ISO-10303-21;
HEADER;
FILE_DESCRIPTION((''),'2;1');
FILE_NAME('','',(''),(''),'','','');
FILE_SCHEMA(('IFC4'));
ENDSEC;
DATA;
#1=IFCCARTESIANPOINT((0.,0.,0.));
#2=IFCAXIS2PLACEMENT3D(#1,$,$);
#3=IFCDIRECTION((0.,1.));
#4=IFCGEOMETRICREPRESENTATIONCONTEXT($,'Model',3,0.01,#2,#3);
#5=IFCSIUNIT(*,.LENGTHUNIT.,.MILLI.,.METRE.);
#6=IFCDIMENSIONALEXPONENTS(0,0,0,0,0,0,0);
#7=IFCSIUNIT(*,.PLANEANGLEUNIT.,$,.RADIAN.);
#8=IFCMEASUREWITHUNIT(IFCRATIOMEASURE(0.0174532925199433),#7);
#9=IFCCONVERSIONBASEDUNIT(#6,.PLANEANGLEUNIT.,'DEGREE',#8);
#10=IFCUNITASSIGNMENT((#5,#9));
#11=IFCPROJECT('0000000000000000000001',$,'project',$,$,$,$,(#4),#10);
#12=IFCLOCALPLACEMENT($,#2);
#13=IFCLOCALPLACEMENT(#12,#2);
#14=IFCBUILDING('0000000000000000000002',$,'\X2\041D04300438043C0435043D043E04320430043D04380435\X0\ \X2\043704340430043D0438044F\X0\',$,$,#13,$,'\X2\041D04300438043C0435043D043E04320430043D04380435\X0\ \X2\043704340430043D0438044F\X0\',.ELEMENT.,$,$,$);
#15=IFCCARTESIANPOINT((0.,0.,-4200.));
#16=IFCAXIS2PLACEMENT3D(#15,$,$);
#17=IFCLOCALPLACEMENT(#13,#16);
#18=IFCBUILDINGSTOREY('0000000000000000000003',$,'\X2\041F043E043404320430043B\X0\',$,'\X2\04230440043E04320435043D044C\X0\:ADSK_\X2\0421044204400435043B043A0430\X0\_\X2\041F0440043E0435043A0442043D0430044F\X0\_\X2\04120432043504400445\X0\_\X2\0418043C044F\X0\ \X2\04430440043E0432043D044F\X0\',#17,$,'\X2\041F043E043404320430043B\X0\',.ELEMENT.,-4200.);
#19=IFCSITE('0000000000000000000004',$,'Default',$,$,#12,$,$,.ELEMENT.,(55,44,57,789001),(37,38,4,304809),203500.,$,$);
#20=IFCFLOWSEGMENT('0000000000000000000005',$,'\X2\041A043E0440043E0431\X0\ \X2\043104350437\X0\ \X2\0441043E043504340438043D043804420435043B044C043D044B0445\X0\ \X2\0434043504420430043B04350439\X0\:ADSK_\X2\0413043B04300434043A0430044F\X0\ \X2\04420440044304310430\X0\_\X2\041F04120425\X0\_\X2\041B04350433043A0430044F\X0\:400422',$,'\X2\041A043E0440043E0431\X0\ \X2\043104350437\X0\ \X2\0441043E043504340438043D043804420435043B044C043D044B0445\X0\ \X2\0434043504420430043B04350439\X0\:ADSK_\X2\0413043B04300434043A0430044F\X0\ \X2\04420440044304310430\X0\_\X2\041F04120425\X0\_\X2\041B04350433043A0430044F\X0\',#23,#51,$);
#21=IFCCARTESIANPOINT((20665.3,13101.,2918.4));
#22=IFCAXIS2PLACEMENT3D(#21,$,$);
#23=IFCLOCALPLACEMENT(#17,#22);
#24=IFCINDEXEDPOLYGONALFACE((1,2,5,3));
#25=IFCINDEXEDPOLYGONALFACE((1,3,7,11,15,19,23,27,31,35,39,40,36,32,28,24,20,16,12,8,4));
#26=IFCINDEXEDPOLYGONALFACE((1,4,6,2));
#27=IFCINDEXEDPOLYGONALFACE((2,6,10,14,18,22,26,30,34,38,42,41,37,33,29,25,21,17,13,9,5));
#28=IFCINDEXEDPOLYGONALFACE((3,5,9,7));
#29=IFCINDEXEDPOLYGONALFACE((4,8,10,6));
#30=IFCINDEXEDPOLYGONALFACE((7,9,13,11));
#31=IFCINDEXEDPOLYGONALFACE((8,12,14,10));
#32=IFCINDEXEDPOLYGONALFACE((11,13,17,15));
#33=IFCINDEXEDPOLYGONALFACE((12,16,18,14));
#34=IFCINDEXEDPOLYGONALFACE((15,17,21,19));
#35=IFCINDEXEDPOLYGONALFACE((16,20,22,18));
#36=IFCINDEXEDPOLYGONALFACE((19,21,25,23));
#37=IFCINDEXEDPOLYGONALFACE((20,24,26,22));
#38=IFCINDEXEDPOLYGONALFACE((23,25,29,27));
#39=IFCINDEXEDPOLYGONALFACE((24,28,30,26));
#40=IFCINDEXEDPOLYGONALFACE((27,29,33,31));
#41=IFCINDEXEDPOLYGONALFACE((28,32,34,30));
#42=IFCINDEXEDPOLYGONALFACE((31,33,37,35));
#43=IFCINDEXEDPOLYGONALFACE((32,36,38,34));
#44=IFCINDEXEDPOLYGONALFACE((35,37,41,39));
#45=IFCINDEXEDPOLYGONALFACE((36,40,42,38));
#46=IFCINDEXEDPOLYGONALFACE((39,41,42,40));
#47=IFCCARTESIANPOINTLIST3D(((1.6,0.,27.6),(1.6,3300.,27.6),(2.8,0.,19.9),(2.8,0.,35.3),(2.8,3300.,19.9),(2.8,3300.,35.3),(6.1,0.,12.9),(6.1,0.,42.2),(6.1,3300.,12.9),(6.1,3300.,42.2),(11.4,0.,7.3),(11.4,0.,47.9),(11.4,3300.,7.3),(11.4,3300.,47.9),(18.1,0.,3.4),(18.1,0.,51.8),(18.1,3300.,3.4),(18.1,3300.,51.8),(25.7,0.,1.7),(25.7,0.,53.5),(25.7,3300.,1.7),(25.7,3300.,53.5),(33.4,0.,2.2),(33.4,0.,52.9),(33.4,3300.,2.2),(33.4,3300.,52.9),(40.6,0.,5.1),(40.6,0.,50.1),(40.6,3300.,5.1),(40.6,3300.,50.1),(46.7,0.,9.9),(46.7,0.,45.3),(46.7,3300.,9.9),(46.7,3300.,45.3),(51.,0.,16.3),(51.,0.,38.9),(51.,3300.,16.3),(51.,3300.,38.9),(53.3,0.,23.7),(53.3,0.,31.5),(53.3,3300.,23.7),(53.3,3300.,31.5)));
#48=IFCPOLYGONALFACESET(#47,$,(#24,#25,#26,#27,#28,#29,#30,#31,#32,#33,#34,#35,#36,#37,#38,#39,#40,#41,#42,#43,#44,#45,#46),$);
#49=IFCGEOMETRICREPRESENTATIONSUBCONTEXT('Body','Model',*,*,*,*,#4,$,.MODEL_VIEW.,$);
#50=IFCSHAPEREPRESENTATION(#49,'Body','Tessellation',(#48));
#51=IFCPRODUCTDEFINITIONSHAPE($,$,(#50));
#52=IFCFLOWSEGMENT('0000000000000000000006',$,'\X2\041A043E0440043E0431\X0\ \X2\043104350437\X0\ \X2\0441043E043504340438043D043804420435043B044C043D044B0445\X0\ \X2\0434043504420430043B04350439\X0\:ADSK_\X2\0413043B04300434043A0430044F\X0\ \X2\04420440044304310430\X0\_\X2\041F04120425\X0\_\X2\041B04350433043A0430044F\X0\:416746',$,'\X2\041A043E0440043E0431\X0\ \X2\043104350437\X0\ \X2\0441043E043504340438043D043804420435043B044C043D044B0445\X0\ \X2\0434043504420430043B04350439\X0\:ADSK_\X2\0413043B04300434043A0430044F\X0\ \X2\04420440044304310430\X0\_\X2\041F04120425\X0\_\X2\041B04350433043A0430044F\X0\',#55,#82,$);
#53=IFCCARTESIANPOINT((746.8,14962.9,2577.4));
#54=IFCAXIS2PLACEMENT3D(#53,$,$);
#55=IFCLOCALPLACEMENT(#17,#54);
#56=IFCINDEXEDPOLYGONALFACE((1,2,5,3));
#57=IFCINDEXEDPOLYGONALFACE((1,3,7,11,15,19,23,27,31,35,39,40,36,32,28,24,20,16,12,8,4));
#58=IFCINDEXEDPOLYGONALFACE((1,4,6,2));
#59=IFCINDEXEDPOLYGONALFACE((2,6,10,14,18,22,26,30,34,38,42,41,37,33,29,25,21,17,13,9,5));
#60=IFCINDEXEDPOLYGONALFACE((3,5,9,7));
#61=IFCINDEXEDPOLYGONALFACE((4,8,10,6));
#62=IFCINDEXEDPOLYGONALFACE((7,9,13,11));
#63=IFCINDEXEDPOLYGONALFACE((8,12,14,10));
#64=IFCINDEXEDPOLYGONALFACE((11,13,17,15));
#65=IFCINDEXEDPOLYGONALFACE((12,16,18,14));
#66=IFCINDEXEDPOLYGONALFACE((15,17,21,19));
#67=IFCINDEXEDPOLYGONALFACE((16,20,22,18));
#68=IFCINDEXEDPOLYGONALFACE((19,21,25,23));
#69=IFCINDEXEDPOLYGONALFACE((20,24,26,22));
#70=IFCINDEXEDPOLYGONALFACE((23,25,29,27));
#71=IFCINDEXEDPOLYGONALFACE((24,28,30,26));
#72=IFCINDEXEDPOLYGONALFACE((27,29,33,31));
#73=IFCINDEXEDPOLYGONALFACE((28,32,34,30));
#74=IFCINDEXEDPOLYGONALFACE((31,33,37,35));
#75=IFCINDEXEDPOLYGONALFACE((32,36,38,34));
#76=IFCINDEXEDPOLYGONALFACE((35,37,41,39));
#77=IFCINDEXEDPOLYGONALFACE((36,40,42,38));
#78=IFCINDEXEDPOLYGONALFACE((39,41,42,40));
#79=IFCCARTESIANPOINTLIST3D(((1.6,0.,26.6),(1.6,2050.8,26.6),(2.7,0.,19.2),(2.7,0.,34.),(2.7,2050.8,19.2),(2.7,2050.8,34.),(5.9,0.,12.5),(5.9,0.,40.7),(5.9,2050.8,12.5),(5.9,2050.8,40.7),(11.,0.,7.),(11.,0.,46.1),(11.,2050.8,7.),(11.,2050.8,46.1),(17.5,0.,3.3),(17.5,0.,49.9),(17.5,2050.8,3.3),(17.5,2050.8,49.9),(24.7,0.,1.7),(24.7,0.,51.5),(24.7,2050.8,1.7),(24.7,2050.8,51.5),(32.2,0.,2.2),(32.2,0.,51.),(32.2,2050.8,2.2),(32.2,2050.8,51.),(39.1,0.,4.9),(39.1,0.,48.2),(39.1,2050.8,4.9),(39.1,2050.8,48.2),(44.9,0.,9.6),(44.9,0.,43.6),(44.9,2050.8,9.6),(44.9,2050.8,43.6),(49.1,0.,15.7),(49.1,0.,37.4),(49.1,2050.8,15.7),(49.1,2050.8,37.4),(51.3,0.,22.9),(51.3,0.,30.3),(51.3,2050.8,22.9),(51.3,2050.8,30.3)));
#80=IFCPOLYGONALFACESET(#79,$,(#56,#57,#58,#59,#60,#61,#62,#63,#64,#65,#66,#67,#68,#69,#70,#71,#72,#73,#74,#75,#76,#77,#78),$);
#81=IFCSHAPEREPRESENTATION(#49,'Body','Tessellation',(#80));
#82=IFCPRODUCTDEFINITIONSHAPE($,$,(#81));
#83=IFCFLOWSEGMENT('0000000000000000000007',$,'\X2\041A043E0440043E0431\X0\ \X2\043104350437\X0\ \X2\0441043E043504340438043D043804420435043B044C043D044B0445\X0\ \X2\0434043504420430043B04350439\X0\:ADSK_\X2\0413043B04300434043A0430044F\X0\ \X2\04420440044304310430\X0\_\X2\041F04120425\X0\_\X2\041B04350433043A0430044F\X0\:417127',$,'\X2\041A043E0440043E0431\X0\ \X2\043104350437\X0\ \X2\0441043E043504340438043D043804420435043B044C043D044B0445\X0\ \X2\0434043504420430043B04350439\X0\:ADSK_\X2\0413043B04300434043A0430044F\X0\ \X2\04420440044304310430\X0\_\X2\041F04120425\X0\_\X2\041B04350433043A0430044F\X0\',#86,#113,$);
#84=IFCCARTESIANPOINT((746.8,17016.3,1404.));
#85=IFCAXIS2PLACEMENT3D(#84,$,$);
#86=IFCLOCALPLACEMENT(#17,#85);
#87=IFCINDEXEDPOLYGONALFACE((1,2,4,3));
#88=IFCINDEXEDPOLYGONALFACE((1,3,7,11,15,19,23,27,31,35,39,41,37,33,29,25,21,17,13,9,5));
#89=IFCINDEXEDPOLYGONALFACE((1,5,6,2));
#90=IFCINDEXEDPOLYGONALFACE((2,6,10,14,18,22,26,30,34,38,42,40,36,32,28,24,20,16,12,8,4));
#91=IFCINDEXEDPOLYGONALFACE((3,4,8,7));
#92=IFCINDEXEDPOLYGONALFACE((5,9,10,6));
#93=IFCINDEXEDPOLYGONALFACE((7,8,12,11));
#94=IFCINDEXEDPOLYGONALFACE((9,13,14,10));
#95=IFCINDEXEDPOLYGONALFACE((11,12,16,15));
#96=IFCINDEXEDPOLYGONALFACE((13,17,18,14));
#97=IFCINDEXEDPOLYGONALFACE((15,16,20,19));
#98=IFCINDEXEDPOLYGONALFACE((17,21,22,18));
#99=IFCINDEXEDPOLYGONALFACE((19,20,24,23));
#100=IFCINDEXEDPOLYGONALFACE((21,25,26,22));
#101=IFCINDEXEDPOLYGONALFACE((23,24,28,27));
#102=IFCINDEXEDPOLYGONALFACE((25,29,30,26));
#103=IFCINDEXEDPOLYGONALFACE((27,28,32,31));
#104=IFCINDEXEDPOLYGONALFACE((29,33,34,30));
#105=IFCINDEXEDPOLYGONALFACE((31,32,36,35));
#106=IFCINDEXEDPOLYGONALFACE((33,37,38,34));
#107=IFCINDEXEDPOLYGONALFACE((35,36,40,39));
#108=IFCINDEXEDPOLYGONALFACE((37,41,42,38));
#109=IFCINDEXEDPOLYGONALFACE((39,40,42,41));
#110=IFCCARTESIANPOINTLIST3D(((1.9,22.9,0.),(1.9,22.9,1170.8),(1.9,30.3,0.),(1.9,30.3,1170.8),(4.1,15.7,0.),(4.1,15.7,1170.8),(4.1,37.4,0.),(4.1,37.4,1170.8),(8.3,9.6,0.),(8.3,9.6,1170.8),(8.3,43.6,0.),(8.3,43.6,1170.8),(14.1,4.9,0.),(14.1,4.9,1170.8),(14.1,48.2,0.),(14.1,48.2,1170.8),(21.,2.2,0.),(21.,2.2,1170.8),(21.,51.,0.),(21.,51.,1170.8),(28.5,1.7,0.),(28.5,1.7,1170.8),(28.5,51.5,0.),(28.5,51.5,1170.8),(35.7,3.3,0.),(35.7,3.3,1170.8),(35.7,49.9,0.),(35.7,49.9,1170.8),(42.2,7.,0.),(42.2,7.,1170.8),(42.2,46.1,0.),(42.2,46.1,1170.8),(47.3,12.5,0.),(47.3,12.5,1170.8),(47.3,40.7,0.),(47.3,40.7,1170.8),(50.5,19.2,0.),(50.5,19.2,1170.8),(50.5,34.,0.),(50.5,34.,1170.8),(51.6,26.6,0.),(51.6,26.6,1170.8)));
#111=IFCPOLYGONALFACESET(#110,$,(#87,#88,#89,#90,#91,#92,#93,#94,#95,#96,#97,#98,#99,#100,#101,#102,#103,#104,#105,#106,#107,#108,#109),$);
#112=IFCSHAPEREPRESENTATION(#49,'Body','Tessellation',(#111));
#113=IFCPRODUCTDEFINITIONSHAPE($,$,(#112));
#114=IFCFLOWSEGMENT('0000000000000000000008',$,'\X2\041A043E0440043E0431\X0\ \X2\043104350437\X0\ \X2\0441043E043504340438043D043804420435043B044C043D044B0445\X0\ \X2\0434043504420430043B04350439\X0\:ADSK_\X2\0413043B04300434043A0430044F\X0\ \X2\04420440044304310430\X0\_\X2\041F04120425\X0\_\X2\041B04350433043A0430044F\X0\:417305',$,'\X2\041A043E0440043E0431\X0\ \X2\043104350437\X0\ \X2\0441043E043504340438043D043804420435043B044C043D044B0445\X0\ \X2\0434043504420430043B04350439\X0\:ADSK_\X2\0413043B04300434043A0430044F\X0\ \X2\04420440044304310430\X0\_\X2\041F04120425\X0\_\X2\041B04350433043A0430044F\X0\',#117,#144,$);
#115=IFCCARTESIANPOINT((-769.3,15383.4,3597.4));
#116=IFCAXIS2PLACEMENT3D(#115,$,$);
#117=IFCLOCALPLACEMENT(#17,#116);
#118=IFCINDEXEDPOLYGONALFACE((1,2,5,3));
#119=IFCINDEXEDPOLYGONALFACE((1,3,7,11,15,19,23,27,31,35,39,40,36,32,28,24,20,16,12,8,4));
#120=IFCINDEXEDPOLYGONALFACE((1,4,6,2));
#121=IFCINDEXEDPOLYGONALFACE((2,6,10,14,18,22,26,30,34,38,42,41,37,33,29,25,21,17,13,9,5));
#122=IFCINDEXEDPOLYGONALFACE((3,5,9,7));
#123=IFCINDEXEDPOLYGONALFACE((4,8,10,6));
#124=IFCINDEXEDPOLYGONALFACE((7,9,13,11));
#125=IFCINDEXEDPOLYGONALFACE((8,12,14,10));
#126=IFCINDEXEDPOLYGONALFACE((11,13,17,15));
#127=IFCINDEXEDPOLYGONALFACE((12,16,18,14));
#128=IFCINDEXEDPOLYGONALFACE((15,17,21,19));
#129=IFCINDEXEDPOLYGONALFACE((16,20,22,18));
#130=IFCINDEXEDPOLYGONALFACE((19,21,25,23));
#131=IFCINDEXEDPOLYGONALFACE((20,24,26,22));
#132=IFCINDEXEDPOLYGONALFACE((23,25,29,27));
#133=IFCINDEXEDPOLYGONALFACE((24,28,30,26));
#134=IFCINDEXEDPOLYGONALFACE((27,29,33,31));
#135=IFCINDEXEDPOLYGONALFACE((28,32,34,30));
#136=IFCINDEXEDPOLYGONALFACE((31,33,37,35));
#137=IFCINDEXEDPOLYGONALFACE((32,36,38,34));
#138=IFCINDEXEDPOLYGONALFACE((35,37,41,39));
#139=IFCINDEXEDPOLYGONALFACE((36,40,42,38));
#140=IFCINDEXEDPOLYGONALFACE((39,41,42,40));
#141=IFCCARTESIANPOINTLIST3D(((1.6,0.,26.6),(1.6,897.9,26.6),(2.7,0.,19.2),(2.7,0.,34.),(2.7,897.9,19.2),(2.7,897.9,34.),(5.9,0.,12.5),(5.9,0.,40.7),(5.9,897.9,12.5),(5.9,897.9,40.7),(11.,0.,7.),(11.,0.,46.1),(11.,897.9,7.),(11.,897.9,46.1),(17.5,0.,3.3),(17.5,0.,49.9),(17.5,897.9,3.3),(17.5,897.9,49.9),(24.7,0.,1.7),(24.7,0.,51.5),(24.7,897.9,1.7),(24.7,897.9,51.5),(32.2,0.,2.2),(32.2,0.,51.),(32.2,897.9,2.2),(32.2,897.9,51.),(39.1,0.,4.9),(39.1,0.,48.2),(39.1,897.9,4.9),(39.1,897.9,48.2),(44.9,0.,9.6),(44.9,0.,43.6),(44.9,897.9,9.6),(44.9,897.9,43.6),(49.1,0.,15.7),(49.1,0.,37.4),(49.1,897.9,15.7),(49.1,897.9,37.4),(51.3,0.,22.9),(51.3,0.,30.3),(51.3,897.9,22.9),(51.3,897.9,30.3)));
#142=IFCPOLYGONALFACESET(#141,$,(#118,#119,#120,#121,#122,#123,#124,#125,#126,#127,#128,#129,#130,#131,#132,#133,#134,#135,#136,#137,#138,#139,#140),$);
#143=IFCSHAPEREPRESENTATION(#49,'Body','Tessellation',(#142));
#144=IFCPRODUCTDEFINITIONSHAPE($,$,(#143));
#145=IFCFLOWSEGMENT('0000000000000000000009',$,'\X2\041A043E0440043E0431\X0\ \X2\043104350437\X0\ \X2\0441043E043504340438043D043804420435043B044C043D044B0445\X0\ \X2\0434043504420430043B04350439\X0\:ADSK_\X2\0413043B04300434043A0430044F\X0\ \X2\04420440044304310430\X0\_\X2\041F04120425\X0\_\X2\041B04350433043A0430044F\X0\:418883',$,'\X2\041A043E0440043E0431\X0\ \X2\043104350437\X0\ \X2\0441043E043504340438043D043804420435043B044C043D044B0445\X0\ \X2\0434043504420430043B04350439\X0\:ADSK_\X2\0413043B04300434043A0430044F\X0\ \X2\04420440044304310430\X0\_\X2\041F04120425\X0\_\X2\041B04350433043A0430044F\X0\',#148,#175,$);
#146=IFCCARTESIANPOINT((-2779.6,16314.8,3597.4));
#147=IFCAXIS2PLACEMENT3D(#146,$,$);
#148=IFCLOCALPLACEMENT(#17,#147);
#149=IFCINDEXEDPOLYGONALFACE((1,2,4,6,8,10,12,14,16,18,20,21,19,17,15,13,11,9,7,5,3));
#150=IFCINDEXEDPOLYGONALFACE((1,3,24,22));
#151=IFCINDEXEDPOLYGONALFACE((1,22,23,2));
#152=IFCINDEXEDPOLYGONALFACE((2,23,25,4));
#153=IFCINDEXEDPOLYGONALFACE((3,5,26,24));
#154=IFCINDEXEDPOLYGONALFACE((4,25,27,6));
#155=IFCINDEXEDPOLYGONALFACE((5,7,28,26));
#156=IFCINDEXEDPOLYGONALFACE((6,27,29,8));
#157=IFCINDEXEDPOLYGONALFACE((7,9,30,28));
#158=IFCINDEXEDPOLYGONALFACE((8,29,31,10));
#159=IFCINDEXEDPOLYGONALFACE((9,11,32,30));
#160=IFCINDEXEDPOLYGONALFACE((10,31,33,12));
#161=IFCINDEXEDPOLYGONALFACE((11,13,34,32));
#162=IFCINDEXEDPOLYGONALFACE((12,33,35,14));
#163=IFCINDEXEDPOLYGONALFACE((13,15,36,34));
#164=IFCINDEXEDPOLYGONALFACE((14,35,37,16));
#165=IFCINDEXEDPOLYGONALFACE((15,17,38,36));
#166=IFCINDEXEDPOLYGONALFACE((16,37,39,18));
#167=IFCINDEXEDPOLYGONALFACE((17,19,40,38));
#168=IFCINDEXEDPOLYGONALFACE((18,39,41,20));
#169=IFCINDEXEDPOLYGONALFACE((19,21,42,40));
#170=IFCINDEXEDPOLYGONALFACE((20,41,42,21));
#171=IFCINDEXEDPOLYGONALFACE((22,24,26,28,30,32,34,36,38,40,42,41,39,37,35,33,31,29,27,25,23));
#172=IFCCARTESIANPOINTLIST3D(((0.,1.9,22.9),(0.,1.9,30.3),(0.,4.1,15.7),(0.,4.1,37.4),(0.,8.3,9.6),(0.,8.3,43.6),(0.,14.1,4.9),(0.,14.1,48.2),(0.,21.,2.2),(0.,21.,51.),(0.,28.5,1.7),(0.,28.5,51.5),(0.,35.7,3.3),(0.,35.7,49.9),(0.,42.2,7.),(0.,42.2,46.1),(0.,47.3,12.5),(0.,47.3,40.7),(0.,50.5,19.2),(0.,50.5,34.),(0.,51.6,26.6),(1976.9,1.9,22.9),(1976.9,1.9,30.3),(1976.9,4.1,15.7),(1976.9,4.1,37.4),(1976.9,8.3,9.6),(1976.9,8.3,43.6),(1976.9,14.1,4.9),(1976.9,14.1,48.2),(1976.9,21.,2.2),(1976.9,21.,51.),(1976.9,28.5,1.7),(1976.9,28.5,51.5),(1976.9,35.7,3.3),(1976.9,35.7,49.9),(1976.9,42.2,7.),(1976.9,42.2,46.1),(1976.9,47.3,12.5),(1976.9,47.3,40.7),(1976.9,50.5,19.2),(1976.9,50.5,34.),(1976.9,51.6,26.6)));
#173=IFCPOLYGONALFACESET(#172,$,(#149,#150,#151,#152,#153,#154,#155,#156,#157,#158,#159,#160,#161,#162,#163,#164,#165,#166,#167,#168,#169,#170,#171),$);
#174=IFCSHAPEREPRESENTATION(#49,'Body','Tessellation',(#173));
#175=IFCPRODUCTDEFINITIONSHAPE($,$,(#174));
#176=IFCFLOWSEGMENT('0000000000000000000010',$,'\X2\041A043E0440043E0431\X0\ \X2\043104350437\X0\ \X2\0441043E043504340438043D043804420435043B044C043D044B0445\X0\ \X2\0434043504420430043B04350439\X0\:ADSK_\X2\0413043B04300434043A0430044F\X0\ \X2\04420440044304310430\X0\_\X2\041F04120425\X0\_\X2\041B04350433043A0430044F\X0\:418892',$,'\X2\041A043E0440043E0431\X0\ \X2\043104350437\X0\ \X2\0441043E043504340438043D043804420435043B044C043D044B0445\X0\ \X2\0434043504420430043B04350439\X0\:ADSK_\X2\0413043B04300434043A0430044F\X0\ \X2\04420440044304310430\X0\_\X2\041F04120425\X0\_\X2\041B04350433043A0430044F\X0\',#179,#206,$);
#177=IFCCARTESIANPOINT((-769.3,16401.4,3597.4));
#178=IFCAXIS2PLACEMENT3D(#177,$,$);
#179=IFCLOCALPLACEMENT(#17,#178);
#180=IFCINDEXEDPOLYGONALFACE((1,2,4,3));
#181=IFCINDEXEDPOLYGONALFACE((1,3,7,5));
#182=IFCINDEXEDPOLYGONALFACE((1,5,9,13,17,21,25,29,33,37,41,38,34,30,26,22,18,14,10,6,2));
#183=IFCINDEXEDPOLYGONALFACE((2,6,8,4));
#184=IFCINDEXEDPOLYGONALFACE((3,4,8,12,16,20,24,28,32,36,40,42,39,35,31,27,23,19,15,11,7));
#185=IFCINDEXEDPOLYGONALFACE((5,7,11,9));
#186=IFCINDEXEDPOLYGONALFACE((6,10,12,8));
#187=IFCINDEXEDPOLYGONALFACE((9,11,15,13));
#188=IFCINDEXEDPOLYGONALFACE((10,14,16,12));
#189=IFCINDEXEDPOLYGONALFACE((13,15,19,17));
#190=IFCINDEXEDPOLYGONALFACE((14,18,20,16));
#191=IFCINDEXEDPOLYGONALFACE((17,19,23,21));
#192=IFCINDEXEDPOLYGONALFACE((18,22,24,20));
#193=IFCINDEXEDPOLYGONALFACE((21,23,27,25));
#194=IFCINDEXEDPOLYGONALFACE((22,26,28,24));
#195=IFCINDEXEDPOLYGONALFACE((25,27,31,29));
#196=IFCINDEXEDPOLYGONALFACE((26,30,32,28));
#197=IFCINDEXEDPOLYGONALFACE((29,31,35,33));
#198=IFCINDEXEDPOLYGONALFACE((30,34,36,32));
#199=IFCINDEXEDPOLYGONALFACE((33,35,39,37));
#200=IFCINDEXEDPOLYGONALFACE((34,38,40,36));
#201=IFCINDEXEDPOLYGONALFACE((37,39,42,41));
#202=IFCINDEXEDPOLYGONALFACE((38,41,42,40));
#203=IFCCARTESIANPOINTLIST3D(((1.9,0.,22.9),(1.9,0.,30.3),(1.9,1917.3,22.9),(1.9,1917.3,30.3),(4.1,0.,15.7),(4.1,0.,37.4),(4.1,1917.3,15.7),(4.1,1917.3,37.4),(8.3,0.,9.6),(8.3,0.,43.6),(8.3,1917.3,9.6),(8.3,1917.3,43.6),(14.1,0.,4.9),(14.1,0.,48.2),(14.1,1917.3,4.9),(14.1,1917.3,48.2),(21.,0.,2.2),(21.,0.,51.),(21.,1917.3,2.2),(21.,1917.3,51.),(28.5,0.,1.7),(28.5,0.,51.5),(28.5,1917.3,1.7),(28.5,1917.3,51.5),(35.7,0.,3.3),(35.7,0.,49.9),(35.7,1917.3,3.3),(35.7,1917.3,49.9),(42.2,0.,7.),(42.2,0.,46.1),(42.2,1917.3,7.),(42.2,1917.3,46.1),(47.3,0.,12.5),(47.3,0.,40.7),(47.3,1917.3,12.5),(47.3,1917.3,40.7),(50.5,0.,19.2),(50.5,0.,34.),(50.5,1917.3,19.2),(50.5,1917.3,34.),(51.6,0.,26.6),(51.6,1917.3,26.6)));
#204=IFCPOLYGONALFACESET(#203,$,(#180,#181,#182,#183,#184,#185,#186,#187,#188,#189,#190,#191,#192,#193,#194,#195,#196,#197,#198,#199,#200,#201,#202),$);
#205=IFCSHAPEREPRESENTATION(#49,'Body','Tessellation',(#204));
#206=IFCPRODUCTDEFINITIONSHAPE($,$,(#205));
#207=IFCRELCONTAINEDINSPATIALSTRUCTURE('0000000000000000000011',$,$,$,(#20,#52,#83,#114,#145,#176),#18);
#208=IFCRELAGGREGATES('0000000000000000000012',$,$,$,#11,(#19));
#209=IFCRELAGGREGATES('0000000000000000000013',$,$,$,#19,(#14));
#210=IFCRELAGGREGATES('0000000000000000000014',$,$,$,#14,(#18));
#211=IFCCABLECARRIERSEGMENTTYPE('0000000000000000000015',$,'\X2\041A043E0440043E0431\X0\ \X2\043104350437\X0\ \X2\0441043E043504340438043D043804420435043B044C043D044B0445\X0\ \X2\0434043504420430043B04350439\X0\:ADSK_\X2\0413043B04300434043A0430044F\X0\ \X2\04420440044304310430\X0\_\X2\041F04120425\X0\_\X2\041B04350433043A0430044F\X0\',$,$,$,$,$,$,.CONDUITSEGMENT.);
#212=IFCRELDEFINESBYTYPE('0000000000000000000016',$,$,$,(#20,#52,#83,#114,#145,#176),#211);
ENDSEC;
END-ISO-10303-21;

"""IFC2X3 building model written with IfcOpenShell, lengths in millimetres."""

from ifc_helpers import new_model, entity, si_unit, converted_unit, direction, frame, frame_2d, origin, place, context, subcontext, project, spatial, circle, extrude, type_object, element, save


model = new_model("IFC2X3")

# Units and contexts
model_context = context("Model", 3, precision=0.01, world=origin(), true_north=direction((0.0, 1.0)))
body_context = subcontext(model_context, "Body", "Model", "MODEL_VIEW")
ifc_project = project(units=[si_unit("LENGTHUNIT", "METRE", prefix="MILLI"), converted_unit("PLANEANGLEUNIT", "DEGREE", entity("IfcRatioMeasure", 0.0174532925199433), si_unit("PLANEANGLEUNIT", "RADIAN"), dimensions=[0, 0, 0, 0, 0, 0, 0])], contexts=[model_context])

# Site, building, storey
site_placement = place(None, frame((0.0, 0.0, 0.0)))
site = spatial("IfcSite", under=ifc_project, at=site_placement, Name="Default", CompositionType="ELEMENT", RefLatitude=(55, 44, 57, 789001), RefLongitude=(37, 38, 4, 304809), RefElevation=203500.0)
building_placement = place(site_placement, origin())
building = spatial("IfcBuilding", under=site, at=building_placement, Name="Наименование здания", LongName="Наименование здания", CompositionType="ELEMENT")
storey_placement = place(building_placement, frame((0.0, 0.0, -4200.0)))
storey = spatial("IfcBuildingStorey", under=building, at=storey_placement, Name="Подвал", ObjectType="Уровень:ADSK_Стрелка_Проектная_Вверх_Имя уровня", LongName="Подвал", CompositionType="ELEMENT", Elevation=-4200.0)

# Flow segments
cable_carrier_segment_type_1 = type_object("IfcCableCarrierSegmentType", Name="Короб без соединительных деталей:ADSK_Гладкая труба_ПВХ_Легкая", PredefinedType="CONDUITSEGMENT")
flow_segment_1_placement = place(storey_placement, frame((20665.3, 13101.0, 2918.4)))
element("IfcFlowSegment", 1, at=flow_segment_1_placement, inside=storey, type_object=cable_carrier_segment_type_1, Name="Короб без соединительных деталей:ADSK_Гладкая труба_ПВХ_Легкая:400422", ObjectType="Короб без соединительных деталей:ADSK_Гладкая труба_ПВХ_Легкая", context=body_context, shape_type="SweptSolid", body=[
    extrude(circle(Radius=26.0, at=frame_2d((0.0, 0.0), x_axis=(1.0, 0.0))), frame((27.6, 0.0, 27.6), z_axis=(0.0, 1.0, 0.0), x_axis=(-1.0, 0.0, 0.0)), (0.0, 0.0, 1.0), 3300.0),
])
flow_segment_2_placement = place(storey_placement, frame((746.8, 14962.9, 2577.4)))
element("IfcFlowSegment", 2, at=flow_segment_2_placement, inside=storey, type_object=cable_carrier_segment_type_1, Name="Короб без соединительных деталей:ADSK_Гладкая труба_ПВХ_Легкая:416746", ObjectType="Короб без соединительных деталей:ADSK_Гладкая труба_ПВХ_Легкая", context=body_context, shape_type="SweptSolid", body=[
    extrude(circle(Radius=25.0, at=frame_2d((0.0, 0.0), x_axis=(1.0, 0.0))), frame((26.6, 0.0, 26.6), z_axis=(0.0, 1.0, 0.0), x_axis=(-1.0, 0.0, 0.0)), (0.0, 0.0, 1.0), 2050.8),
])
flow_segment_3_placement = place(storey_placement, frame((746.8, 17016.3, 1404.0)))
element("IfcFlowSegment", 3, at=flow_segment_3_placement, inside=storey, type_object=cable_carrier_segment_type_1, Name="Короб без соединительных деталей:ADSK_Гладкая труба_ПВХ_Легкая:417127", ObjectType="Короб без соединительных деталей:ADSK_Гладкая труба_ПВХ_Легкая", context=body_context, shape_type="SweptSolid", body=[
    extrude(circle(Radius=25.0, at=frame_2d((0.0, 0.0), x_axis=(1.0, 0.0))), frame((26.6, 26.6, 0.0)), (0.0, 0.0, 1.0), 1170.8),
])
flow_segment_4_placement = place(storey_placement, frame((-769.3, 15383.4, 3597.4)))
element("IfcFlowSegment", 4, at=flow_segment_4_placement, inside=storey, type_object=cable_carrier_segment_type_1, Name="Короб без соединительных деталей:ADSK_Гладкая труба_ПВХ_Легкая:417305", ObjectType="Короб без соединительных деталей:ADSK_Гладкая труба_ПВХ_Легкая", context=body_context, shape_type="SweptSolid", body=[
    extrude(circle(Radius=25.0, at=frame_2d((0.0, 0.0), x_axis=(1.0, 0.0))), frame((26.6, 0.0, 26.6), z_axis=(0.0, 1.0, 0.0), x_axis=(-1.0, 0.0, 0.0)), (0.0, 0.0, 1.0), 897.9),
])
flow_segment_5_placement = place(storey_placement, frame((-2779.6, 16314.8, 3597.4)))
element("IfcFlowSegment", 5, at=flow_segment_5_placement, inside=storey, type_object=cable_carrier_segment_type_1, Name="Короб без соединительных деталей:ADSK_Гладкая труба_ПВХ_Легкая:418883", ObjectType="Короб без соединительных деталей:ADSK_Гладкая труба_ПВХ_Легкая", context=body_context, shape_type="SweptSolid", body=[
    extrude(circle(Radius=25.0, at=frame_2d((0.0, 0.0), x_axis=(1.0, 0.0))), frame((0.0, 26.6, 26.6), z_axis=(1.0, 0.0, 0.0), x_axis=(0.0, 1.0, 0.0)), (0.0, 0.0, 1.0), 1976.9),
])
flow_segment_6_placement = place(storey_placement, frame((-769.3, 16401.4, 3597.4)))
element("IfcFlowSegment", 6, at=flow_segment_6_placement, inside=storey, type_object=cable_carrier_segment_type_1, Name="Короб без соединительных деталей:ADSK_Гладкая труба_ПВХ_Легкая:418892", ObjectType="Короб без соединительных деталей:ADSK_Гладкая труба_ПВХ_Легкая", context=body_context, shape_type="SweptSolid", body=[
    extrude(circle(Radius=25.0, at=frame_2d((0.0, 0.0), x_axis=(1.0, 0.0))), frame((26.6, 0.0, 26.6), z_axis=(0.0, 1.0, 0.0), x_axis=(1.0, 0.0, 0.0)), (0.0, 0.0, 1.0), 1917.3),
])

save(model, "model.ifc")
